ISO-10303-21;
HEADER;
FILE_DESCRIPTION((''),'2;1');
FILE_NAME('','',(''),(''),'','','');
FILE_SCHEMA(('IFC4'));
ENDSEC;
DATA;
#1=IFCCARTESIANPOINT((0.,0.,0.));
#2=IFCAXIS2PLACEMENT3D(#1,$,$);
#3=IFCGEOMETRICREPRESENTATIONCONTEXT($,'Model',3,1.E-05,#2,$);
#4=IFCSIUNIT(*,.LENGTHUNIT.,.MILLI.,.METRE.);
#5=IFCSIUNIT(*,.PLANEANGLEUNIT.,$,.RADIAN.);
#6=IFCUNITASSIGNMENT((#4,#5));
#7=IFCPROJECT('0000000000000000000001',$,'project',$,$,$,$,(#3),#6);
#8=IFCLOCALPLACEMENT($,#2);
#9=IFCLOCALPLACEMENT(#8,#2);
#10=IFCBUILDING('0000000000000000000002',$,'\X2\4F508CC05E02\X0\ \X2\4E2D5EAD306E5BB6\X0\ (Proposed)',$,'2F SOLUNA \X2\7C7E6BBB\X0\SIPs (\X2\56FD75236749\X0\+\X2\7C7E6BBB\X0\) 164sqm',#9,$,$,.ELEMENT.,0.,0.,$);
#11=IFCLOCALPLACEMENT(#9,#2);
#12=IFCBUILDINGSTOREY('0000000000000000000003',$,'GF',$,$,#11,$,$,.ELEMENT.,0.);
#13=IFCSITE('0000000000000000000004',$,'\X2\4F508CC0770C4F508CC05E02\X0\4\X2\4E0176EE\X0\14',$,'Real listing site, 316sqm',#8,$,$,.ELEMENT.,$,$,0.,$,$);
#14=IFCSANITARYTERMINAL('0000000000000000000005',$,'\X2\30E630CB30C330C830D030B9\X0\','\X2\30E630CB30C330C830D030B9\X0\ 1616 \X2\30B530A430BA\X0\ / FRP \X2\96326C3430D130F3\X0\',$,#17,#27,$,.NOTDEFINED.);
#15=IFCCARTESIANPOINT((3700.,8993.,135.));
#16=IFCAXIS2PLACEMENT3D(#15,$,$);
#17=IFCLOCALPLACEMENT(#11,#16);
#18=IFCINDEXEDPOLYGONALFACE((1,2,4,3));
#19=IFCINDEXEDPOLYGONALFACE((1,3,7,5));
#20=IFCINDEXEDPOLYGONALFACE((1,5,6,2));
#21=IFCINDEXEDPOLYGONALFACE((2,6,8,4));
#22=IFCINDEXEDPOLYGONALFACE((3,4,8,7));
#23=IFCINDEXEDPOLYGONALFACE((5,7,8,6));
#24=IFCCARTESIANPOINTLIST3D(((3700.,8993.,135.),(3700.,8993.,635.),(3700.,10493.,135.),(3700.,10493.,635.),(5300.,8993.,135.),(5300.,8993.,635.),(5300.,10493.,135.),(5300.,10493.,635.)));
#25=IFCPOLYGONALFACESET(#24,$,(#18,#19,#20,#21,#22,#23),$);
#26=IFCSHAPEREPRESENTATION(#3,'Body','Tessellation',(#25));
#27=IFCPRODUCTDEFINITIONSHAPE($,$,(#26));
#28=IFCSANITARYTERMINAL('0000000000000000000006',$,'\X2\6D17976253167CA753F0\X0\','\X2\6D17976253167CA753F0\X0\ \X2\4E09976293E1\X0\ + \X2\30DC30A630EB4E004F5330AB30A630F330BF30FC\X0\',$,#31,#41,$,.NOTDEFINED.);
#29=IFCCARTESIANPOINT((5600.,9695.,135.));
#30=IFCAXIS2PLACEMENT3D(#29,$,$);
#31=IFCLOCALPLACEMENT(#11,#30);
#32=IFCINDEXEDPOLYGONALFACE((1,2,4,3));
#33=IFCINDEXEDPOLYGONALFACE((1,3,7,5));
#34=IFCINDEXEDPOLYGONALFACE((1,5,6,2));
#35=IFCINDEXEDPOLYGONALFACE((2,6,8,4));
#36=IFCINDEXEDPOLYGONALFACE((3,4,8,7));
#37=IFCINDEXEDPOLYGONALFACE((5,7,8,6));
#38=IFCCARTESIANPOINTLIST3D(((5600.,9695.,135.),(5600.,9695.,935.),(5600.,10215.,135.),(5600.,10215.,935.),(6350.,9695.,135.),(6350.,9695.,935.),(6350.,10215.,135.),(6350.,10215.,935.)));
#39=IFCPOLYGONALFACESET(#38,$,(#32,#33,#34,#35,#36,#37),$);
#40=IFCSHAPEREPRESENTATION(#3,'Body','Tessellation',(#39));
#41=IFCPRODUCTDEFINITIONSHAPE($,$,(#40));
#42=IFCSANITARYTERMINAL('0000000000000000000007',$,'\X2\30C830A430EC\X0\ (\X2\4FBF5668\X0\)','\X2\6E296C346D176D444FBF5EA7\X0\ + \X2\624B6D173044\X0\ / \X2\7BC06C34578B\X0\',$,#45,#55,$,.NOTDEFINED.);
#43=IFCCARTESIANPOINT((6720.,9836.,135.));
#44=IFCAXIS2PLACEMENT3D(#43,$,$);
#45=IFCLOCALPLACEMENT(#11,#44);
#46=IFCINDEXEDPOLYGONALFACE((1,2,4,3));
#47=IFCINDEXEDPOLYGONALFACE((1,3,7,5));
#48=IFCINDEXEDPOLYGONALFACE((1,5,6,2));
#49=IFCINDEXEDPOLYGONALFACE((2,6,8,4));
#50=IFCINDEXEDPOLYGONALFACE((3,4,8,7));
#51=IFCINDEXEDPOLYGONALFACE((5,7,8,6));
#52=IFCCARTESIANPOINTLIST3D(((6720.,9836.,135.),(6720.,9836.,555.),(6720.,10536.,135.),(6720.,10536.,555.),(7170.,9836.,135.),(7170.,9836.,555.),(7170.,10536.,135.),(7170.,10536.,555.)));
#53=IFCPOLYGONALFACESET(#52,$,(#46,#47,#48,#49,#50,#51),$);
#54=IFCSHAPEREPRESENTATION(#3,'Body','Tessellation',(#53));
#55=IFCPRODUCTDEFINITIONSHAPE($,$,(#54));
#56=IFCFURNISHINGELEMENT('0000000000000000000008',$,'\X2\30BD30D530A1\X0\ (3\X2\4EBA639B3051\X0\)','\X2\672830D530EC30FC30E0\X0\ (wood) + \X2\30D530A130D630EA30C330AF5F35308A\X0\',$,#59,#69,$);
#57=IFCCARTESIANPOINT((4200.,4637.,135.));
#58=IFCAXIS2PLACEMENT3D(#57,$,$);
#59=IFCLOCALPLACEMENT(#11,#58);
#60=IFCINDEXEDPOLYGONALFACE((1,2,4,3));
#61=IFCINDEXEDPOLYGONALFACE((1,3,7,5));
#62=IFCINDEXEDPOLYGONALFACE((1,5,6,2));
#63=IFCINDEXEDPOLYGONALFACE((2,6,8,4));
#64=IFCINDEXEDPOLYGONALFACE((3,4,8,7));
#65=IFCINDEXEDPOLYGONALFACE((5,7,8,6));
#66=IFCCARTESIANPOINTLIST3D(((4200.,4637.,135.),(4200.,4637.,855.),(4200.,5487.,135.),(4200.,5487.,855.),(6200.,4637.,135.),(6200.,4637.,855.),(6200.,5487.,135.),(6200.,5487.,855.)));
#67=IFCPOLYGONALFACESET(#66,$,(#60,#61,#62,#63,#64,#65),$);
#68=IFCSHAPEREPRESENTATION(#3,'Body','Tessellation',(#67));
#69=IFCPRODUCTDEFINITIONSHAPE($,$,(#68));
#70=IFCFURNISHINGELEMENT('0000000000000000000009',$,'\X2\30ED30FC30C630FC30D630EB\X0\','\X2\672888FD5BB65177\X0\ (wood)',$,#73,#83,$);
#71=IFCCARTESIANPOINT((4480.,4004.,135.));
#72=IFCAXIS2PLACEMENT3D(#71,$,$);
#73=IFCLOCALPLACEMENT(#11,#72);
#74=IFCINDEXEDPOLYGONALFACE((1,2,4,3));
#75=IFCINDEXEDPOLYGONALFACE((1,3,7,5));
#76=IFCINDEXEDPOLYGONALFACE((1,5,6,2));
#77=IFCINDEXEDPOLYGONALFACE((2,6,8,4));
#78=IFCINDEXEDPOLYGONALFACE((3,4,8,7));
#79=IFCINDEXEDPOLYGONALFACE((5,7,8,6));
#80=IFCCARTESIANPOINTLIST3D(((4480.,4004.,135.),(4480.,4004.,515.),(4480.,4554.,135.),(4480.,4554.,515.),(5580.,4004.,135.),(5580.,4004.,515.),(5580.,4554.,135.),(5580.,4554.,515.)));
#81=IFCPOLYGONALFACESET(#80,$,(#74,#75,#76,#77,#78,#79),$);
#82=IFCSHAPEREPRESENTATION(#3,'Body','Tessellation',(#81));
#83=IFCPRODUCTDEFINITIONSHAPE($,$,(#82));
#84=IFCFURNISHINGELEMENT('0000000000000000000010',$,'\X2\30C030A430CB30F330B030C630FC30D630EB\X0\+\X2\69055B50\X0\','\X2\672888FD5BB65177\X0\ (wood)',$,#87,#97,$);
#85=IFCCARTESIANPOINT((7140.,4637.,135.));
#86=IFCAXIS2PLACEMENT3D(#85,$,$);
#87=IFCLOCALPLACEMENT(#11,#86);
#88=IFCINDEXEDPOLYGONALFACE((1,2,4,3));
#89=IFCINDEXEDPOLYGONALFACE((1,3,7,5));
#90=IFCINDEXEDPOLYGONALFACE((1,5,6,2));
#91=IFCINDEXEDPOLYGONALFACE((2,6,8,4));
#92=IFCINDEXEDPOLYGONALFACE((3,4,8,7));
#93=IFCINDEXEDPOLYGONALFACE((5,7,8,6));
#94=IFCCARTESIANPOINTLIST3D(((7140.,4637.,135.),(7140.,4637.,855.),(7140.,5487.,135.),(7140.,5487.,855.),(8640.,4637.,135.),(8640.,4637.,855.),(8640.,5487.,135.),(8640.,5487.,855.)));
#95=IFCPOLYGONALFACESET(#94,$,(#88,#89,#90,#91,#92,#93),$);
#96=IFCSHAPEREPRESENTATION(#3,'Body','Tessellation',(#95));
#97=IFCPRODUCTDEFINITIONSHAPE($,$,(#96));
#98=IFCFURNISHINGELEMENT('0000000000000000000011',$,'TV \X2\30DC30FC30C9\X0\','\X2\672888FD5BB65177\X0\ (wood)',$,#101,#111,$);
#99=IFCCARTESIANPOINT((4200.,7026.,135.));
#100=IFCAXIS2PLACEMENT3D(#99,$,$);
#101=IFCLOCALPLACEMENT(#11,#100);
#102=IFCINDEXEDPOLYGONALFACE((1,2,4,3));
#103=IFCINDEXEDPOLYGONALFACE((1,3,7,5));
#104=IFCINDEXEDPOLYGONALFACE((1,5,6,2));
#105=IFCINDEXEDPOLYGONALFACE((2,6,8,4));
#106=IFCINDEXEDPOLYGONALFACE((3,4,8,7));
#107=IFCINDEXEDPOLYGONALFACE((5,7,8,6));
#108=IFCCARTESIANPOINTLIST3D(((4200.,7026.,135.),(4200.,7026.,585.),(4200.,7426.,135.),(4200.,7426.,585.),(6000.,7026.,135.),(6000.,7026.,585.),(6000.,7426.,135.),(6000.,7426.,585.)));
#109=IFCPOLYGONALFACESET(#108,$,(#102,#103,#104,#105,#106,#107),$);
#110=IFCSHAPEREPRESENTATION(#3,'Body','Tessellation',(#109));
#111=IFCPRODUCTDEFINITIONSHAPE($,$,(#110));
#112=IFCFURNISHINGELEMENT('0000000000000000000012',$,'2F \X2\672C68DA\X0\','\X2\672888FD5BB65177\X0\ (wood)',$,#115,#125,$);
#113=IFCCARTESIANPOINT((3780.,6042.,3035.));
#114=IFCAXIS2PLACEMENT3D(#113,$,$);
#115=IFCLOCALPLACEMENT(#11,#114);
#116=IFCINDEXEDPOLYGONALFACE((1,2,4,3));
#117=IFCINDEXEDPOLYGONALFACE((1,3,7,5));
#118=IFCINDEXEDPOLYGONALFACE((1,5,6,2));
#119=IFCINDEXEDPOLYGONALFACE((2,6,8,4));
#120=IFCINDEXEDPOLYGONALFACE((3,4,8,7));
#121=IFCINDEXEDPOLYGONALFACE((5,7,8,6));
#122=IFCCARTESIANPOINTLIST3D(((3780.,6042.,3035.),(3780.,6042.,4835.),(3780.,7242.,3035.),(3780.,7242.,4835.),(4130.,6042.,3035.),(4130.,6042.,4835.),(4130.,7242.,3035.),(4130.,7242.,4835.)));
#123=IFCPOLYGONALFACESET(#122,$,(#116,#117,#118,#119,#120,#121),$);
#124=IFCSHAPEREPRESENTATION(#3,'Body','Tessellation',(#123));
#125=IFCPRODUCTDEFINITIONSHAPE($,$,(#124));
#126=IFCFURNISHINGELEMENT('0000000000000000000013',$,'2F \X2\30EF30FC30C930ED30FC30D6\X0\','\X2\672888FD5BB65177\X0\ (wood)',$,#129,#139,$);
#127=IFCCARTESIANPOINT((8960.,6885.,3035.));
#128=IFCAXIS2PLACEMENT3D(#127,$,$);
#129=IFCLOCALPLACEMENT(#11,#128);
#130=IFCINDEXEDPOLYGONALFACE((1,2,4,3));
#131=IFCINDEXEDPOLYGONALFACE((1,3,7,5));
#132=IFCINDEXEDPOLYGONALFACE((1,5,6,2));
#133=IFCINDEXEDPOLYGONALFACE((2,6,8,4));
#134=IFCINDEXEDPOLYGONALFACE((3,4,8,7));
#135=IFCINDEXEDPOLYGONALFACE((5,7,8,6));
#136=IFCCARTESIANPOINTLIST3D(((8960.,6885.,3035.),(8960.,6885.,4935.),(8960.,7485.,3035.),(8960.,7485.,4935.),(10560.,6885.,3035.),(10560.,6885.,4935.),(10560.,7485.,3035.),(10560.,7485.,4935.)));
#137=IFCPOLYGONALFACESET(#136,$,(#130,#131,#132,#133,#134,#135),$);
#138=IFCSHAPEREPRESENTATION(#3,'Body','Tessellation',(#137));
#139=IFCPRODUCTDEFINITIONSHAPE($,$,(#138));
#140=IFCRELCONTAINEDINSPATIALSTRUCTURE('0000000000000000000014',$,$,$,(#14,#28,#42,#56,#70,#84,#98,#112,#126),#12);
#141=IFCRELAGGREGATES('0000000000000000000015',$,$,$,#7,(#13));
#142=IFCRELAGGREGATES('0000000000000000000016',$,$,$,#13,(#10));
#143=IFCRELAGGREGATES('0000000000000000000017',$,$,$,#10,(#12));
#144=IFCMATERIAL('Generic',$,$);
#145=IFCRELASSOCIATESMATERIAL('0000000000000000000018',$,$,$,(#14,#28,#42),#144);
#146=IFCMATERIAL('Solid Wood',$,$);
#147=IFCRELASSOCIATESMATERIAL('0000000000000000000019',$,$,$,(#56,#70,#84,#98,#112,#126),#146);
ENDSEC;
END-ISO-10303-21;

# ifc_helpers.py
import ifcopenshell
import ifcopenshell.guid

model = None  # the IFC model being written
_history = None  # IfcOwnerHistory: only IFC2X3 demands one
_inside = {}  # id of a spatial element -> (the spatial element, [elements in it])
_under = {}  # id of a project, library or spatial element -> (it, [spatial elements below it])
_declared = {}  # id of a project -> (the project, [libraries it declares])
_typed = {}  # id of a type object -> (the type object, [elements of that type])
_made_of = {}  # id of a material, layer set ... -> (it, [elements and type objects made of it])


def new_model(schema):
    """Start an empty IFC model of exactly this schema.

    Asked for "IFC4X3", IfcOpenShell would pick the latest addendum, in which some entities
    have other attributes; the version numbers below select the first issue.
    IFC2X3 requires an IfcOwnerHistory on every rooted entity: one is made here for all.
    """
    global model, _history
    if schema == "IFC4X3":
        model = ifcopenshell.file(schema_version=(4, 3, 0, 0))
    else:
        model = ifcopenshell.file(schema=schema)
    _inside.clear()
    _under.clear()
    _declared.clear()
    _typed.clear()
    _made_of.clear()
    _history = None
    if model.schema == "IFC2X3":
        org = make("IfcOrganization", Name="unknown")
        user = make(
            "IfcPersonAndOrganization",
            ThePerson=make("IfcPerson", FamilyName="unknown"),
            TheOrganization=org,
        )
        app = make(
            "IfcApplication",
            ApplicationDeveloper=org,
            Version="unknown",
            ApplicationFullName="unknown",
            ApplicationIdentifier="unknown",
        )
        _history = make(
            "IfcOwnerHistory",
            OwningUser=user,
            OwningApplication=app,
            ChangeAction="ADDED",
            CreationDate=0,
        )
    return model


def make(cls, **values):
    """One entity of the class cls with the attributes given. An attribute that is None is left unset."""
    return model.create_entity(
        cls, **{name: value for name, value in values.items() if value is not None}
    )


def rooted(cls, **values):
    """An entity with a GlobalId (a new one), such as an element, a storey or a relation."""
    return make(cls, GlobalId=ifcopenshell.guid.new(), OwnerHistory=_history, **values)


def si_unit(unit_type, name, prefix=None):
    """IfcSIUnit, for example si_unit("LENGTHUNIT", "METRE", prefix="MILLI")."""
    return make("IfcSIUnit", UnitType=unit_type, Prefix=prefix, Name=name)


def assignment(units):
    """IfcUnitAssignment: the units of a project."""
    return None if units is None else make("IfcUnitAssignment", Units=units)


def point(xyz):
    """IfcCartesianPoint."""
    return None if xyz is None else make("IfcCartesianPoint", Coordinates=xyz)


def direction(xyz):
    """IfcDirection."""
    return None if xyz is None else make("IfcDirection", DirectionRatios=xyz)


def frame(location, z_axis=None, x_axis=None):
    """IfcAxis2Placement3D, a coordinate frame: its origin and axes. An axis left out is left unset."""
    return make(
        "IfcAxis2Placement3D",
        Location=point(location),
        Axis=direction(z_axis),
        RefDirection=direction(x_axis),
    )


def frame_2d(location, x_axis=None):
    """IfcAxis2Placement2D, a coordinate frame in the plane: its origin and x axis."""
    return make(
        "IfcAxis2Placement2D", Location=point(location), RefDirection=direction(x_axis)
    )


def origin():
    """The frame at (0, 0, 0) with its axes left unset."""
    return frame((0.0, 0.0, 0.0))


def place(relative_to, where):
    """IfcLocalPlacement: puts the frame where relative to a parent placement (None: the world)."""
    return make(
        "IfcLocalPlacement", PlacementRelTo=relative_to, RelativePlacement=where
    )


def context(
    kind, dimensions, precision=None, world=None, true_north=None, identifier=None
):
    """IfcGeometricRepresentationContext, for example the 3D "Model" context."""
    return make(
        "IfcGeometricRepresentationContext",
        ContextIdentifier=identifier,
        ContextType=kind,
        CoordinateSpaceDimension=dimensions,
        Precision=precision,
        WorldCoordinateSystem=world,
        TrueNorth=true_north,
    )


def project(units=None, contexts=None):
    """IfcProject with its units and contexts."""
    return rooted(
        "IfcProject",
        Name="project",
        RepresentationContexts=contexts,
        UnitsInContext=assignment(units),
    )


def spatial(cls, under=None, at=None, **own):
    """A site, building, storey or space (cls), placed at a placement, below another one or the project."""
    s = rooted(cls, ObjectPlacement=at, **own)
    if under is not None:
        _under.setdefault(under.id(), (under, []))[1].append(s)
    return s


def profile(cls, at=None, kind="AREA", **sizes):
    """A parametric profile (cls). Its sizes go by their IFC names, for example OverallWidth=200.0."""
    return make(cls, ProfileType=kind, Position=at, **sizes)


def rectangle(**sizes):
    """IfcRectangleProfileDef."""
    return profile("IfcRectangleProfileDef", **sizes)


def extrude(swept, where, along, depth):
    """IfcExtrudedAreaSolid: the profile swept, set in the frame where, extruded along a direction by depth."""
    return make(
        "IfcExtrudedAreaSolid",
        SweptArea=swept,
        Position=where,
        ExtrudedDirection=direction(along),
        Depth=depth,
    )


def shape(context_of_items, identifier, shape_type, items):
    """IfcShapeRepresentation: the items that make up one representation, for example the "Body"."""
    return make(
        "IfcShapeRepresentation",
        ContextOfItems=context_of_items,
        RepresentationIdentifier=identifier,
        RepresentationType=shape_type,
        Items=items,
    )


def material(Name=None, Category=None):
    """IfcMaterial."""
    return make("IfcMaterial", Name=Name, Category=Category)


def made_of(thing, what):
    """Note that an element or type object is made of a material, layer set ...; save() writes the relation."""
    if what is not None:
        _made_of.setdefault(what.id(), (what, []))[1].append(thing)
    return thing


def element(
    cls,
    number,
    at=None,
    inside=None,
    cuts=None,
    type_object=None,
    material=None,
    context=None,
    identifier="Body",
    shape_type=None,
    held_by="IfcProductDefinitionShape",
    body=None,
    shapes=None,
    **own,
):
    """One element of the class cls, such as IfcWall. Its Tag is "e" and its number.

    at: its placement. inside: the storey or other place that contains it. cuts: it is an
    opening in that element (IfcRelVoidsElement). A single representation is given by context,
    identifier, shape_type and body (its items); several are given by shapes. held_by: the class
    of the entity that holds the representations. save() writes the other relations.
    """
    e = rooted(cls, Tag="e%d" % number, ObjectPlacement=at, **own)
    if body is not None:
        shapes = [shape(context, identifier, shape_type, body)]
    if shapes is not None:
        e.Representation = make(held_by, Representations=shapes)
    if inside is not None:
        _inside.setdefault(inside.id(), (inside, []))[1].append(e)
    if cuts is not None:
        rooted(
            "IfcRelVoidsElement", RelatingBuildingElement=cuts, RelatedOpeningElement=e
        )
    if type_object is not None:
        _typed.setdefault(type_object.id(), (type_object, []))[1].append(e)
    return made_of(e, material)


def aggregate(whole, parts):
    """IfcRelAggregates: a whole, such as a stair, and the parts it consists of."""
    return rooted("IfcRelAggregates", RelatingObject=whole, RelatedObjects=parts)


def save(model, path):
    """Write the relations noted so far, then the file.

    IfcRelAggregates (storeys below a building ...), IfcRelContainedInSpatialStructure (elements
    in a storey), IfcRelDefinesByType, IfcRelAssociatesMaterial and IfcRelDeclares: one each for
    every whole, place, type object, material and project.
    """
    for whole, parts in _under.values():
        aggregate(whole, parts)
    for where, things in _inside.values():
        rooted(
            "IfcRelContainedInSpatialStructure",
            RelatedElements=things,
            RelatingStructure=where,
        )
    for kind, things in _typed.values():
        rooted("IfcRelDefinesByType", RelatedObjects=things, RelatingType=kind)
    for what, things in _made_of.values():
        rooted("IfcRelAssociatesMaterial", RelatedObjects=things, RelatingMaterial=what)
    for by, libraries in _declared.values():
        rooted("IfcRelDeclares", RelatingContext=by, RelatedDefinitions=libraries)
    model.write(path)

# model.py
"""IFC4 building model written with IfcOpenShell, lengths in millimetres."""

from ifc_helpers import new_model, si_unit, frame, frame_2d, origin, place, context, project, spatial, rectangle, extrude, material, element, save


model = new_model("IFC4")

# Units and contexts
model_context = context("Model", 3, precision=1e-05, world=origin())
ifc_project = project(units=[si_unit("LENGTHUNIT", "METRE", prefix="MILLI"), si_unit("PLANEANGLEUNIT", "RADIAN")], contexts=[model_context])

# Site, building, storey
site_placement = place(None, origin())
site = spatial("IfcSite", under=ifc_project, at=site_placement, Name="佐賀県佐賀市4丁目14", ObjectType="Real listing site, 316sqm", CompositionType="ELEMENT", RefElevation=0.0)
building_placement = place(site_placement, origin())
building = spatial("IfcBuilding", under=site, at=building_placement, Name="佐賀市 中庭の家 (Proposed)", ObjectType="2F SOLUNA 籾殻SIPs (国産杉+籾殻) 164sqm", CompositionType="ELEMENT", ElevationOfRefHeight=0.0, ElevationOfTerrain=0.0)
storey_placement = place(building_placement, origin())
storey = spatial("IfcBuildingStorey", under=building, at=storey_placement, Name="GF", CompositionType="ELEMENT", Elevation=0.0)

# Shared definitions
ifc_material_1 = material(Name="Generic")

# Shared definitions
ifc_material_2 = material(Name="Solid Wood")

# Sanitary terminals
sanitary_terminal_1_placement = place(storey_placement, frame((3700.0, 8993.0, 135.0)))
element("IfcSanitaryTerminal", 1, at=sanitary_terminal_1_placement, inside=storey, material=ifc_material_1, Name="ユニットバス", Description="ユニットバス 1616 サイズ / FRP 防水パン", PredefinedType="NOTDEFINED", context=model_context, shape_type="SweptSolid", body=[
    extrude(rectangle(XDim=1600.0, YDim=1500.0, at=frame_2d((800.0, 750.0))), frame((3700.0, 8993.0, 135.0)), (0.0, 0.0, 1.0), 500.0),
])
sanitary_terminal_2_placement = place(storey_placement, frame((5600.0, 9695.0, 135.0)))
element("IfcSanitaryTerminal", 2, at=sanitary_terminal_2_placement, inside=storey, material=ifc_material_1, Name="洗面化粧台", Description="洗面化粧台 三面鏡 + ボウル一体カウンター", PredefinedType="NOTDEFINED", context=model_context, shape_type="SweptSolid", body=[
    extrude(rectangle(XDim=750.0, YDim=520.0, at=frame_2d((375.0, 260.0))), frame((5600.0, 9695.0, 135.0)), (0.0, 0.0, 1.0), 800.0),
])
sanitary_terminal_3_placement = place(storey_placement, frame((6720.0, 9836.0, 135.0)))
element("IfcSanitaryTerminal", 3, at=sanitary_terminal_3_placement, inside=storey, material=ifc_material_1, Name="トイレ (便器)", Description="温水洗浄便座 + 手洗い / 節水型", PredefinedType="NOTDEFINED", context=model_context, shape_type="SweptSolid", body=[
    extrude(rectangle(XDim=450.0, YDim=700.0, at=frame_2d((225.0, 350.0))), frame((6720.0, 9836.0, 135.0)), (0.0, 0.0, 1.0), 420.0),
])

# Furnishing elements
furnishing_1_placement = place(storey_placement, frame((4200.0, 4637.0, 135.0)))
element("IfcFurnishingElement", 4, at=furnishing_1_placement, inside=storey, material=ifc_material_2, Name="ソファ (3人掛け)", Description="木フレーム (wood) + ファブリック張り", context=model_context, shape_type="SweptSolid", body=[
    extrude(rectangle(XDim=2000.0, YDim=850.0, at=frame_2d((1000.0, 425.0))), frame((4200.0, 4637.0, 135.0)), (0.0, 0.0, 1.0), 720.0),
])
furnishing_2_placement = place(storey_placement, frame((4480.0, 4004.0, 135.0)))
element("IfcFurnishingElement", 5, at=furnishing_2_placement, inside=storey, material=ifc_material_2, Name="ローテーブル", Description="木製家具 (wood)", context=model_context, shape_type="SweptSolid", body=[
    extrude(rectangle(XDim=1100.0, YDim=550.0, at=frame_2d((550.0, 275.0))), frame((4480.0, 4004.0, 135.0)), (0.0, 0.0, 1.0), 380.0),
])
furnishing_3_placement = place(storey_placement, frame((7140.0, 4637.0, 135.0)))
element("IfcFurnishingElement", 6, at=furnishing_3_placement, inside=storey, material=ifc_material_2, Name="ダイニングテーブル+椅子", Description="木製家具 (wood)", context=model_context, shape_type="SweptSolid", body=[
    extrude(rectangle(XDim=1500.0, YDim=850.0, at=frame_2d((750.0, 425.0))), frame((7140.0, 4637.0, 135.0)), (0.0, 0.0, 1.0), 720.0),
])
furnishing_4_placement = place(storey_placement, frame((4200.0, 7026.0, 135.0)))
element("IfcFurnishingElement", 7, at=furnishing_4_placement, inside=storey, material=ifc_material_2, Name="TV ボード", Description="木製家具 (wood)", context=model_context, shape_type="SweptSolid", body=[
    extrude(rectangle(XDim=1800.0, YDim=400.0, at=frame_2d((900.0, 200.0))), frame((4200.0, 7026.0, 135.0)), (0.0, 0.0, 1.0), 450.0),
])
furnishing_5_placement = place(storey_placement, frame((3780.0, 6042.0, 3035.0)))
element("IfcFurnishingElement", 8, at=furnishing_5_placement, inside=storey, material=ifc_material_2, Name="2F 本棚", Description="木製家具 (wood)", context=model_context, shape_type="SweptSolid", body=[
    extrude(rectangle(XDim=350.0, YDim=1200.0, at=frame_2d((175.0, 600.0))), frame((3780.0, 6042.0, 3035.0)), (0.0, 0.0, 1.0), 1800.0),
])
furnishing_6_placement = place(storey_placement, frame((8960.0, 6885.0, 3035.0)))
element("IfcFurnishingElement", 9, at=furnishing_6_placement, inside=storey, material=ifc_material_2, Name="2F ワードローブ", Description="木製家具 (wood)", context=model_context, shape_type="SweptSolid", body=[
    extrude(rectangle(XDim=1600.0, YDim=600.0, at=frame_2d((800.0, 300.0))), frame((8960.0, 6885.0, 3035.0)), (0.0, 0.0, 1.0), 1900.0),
])

save(model, "model.ifc")
